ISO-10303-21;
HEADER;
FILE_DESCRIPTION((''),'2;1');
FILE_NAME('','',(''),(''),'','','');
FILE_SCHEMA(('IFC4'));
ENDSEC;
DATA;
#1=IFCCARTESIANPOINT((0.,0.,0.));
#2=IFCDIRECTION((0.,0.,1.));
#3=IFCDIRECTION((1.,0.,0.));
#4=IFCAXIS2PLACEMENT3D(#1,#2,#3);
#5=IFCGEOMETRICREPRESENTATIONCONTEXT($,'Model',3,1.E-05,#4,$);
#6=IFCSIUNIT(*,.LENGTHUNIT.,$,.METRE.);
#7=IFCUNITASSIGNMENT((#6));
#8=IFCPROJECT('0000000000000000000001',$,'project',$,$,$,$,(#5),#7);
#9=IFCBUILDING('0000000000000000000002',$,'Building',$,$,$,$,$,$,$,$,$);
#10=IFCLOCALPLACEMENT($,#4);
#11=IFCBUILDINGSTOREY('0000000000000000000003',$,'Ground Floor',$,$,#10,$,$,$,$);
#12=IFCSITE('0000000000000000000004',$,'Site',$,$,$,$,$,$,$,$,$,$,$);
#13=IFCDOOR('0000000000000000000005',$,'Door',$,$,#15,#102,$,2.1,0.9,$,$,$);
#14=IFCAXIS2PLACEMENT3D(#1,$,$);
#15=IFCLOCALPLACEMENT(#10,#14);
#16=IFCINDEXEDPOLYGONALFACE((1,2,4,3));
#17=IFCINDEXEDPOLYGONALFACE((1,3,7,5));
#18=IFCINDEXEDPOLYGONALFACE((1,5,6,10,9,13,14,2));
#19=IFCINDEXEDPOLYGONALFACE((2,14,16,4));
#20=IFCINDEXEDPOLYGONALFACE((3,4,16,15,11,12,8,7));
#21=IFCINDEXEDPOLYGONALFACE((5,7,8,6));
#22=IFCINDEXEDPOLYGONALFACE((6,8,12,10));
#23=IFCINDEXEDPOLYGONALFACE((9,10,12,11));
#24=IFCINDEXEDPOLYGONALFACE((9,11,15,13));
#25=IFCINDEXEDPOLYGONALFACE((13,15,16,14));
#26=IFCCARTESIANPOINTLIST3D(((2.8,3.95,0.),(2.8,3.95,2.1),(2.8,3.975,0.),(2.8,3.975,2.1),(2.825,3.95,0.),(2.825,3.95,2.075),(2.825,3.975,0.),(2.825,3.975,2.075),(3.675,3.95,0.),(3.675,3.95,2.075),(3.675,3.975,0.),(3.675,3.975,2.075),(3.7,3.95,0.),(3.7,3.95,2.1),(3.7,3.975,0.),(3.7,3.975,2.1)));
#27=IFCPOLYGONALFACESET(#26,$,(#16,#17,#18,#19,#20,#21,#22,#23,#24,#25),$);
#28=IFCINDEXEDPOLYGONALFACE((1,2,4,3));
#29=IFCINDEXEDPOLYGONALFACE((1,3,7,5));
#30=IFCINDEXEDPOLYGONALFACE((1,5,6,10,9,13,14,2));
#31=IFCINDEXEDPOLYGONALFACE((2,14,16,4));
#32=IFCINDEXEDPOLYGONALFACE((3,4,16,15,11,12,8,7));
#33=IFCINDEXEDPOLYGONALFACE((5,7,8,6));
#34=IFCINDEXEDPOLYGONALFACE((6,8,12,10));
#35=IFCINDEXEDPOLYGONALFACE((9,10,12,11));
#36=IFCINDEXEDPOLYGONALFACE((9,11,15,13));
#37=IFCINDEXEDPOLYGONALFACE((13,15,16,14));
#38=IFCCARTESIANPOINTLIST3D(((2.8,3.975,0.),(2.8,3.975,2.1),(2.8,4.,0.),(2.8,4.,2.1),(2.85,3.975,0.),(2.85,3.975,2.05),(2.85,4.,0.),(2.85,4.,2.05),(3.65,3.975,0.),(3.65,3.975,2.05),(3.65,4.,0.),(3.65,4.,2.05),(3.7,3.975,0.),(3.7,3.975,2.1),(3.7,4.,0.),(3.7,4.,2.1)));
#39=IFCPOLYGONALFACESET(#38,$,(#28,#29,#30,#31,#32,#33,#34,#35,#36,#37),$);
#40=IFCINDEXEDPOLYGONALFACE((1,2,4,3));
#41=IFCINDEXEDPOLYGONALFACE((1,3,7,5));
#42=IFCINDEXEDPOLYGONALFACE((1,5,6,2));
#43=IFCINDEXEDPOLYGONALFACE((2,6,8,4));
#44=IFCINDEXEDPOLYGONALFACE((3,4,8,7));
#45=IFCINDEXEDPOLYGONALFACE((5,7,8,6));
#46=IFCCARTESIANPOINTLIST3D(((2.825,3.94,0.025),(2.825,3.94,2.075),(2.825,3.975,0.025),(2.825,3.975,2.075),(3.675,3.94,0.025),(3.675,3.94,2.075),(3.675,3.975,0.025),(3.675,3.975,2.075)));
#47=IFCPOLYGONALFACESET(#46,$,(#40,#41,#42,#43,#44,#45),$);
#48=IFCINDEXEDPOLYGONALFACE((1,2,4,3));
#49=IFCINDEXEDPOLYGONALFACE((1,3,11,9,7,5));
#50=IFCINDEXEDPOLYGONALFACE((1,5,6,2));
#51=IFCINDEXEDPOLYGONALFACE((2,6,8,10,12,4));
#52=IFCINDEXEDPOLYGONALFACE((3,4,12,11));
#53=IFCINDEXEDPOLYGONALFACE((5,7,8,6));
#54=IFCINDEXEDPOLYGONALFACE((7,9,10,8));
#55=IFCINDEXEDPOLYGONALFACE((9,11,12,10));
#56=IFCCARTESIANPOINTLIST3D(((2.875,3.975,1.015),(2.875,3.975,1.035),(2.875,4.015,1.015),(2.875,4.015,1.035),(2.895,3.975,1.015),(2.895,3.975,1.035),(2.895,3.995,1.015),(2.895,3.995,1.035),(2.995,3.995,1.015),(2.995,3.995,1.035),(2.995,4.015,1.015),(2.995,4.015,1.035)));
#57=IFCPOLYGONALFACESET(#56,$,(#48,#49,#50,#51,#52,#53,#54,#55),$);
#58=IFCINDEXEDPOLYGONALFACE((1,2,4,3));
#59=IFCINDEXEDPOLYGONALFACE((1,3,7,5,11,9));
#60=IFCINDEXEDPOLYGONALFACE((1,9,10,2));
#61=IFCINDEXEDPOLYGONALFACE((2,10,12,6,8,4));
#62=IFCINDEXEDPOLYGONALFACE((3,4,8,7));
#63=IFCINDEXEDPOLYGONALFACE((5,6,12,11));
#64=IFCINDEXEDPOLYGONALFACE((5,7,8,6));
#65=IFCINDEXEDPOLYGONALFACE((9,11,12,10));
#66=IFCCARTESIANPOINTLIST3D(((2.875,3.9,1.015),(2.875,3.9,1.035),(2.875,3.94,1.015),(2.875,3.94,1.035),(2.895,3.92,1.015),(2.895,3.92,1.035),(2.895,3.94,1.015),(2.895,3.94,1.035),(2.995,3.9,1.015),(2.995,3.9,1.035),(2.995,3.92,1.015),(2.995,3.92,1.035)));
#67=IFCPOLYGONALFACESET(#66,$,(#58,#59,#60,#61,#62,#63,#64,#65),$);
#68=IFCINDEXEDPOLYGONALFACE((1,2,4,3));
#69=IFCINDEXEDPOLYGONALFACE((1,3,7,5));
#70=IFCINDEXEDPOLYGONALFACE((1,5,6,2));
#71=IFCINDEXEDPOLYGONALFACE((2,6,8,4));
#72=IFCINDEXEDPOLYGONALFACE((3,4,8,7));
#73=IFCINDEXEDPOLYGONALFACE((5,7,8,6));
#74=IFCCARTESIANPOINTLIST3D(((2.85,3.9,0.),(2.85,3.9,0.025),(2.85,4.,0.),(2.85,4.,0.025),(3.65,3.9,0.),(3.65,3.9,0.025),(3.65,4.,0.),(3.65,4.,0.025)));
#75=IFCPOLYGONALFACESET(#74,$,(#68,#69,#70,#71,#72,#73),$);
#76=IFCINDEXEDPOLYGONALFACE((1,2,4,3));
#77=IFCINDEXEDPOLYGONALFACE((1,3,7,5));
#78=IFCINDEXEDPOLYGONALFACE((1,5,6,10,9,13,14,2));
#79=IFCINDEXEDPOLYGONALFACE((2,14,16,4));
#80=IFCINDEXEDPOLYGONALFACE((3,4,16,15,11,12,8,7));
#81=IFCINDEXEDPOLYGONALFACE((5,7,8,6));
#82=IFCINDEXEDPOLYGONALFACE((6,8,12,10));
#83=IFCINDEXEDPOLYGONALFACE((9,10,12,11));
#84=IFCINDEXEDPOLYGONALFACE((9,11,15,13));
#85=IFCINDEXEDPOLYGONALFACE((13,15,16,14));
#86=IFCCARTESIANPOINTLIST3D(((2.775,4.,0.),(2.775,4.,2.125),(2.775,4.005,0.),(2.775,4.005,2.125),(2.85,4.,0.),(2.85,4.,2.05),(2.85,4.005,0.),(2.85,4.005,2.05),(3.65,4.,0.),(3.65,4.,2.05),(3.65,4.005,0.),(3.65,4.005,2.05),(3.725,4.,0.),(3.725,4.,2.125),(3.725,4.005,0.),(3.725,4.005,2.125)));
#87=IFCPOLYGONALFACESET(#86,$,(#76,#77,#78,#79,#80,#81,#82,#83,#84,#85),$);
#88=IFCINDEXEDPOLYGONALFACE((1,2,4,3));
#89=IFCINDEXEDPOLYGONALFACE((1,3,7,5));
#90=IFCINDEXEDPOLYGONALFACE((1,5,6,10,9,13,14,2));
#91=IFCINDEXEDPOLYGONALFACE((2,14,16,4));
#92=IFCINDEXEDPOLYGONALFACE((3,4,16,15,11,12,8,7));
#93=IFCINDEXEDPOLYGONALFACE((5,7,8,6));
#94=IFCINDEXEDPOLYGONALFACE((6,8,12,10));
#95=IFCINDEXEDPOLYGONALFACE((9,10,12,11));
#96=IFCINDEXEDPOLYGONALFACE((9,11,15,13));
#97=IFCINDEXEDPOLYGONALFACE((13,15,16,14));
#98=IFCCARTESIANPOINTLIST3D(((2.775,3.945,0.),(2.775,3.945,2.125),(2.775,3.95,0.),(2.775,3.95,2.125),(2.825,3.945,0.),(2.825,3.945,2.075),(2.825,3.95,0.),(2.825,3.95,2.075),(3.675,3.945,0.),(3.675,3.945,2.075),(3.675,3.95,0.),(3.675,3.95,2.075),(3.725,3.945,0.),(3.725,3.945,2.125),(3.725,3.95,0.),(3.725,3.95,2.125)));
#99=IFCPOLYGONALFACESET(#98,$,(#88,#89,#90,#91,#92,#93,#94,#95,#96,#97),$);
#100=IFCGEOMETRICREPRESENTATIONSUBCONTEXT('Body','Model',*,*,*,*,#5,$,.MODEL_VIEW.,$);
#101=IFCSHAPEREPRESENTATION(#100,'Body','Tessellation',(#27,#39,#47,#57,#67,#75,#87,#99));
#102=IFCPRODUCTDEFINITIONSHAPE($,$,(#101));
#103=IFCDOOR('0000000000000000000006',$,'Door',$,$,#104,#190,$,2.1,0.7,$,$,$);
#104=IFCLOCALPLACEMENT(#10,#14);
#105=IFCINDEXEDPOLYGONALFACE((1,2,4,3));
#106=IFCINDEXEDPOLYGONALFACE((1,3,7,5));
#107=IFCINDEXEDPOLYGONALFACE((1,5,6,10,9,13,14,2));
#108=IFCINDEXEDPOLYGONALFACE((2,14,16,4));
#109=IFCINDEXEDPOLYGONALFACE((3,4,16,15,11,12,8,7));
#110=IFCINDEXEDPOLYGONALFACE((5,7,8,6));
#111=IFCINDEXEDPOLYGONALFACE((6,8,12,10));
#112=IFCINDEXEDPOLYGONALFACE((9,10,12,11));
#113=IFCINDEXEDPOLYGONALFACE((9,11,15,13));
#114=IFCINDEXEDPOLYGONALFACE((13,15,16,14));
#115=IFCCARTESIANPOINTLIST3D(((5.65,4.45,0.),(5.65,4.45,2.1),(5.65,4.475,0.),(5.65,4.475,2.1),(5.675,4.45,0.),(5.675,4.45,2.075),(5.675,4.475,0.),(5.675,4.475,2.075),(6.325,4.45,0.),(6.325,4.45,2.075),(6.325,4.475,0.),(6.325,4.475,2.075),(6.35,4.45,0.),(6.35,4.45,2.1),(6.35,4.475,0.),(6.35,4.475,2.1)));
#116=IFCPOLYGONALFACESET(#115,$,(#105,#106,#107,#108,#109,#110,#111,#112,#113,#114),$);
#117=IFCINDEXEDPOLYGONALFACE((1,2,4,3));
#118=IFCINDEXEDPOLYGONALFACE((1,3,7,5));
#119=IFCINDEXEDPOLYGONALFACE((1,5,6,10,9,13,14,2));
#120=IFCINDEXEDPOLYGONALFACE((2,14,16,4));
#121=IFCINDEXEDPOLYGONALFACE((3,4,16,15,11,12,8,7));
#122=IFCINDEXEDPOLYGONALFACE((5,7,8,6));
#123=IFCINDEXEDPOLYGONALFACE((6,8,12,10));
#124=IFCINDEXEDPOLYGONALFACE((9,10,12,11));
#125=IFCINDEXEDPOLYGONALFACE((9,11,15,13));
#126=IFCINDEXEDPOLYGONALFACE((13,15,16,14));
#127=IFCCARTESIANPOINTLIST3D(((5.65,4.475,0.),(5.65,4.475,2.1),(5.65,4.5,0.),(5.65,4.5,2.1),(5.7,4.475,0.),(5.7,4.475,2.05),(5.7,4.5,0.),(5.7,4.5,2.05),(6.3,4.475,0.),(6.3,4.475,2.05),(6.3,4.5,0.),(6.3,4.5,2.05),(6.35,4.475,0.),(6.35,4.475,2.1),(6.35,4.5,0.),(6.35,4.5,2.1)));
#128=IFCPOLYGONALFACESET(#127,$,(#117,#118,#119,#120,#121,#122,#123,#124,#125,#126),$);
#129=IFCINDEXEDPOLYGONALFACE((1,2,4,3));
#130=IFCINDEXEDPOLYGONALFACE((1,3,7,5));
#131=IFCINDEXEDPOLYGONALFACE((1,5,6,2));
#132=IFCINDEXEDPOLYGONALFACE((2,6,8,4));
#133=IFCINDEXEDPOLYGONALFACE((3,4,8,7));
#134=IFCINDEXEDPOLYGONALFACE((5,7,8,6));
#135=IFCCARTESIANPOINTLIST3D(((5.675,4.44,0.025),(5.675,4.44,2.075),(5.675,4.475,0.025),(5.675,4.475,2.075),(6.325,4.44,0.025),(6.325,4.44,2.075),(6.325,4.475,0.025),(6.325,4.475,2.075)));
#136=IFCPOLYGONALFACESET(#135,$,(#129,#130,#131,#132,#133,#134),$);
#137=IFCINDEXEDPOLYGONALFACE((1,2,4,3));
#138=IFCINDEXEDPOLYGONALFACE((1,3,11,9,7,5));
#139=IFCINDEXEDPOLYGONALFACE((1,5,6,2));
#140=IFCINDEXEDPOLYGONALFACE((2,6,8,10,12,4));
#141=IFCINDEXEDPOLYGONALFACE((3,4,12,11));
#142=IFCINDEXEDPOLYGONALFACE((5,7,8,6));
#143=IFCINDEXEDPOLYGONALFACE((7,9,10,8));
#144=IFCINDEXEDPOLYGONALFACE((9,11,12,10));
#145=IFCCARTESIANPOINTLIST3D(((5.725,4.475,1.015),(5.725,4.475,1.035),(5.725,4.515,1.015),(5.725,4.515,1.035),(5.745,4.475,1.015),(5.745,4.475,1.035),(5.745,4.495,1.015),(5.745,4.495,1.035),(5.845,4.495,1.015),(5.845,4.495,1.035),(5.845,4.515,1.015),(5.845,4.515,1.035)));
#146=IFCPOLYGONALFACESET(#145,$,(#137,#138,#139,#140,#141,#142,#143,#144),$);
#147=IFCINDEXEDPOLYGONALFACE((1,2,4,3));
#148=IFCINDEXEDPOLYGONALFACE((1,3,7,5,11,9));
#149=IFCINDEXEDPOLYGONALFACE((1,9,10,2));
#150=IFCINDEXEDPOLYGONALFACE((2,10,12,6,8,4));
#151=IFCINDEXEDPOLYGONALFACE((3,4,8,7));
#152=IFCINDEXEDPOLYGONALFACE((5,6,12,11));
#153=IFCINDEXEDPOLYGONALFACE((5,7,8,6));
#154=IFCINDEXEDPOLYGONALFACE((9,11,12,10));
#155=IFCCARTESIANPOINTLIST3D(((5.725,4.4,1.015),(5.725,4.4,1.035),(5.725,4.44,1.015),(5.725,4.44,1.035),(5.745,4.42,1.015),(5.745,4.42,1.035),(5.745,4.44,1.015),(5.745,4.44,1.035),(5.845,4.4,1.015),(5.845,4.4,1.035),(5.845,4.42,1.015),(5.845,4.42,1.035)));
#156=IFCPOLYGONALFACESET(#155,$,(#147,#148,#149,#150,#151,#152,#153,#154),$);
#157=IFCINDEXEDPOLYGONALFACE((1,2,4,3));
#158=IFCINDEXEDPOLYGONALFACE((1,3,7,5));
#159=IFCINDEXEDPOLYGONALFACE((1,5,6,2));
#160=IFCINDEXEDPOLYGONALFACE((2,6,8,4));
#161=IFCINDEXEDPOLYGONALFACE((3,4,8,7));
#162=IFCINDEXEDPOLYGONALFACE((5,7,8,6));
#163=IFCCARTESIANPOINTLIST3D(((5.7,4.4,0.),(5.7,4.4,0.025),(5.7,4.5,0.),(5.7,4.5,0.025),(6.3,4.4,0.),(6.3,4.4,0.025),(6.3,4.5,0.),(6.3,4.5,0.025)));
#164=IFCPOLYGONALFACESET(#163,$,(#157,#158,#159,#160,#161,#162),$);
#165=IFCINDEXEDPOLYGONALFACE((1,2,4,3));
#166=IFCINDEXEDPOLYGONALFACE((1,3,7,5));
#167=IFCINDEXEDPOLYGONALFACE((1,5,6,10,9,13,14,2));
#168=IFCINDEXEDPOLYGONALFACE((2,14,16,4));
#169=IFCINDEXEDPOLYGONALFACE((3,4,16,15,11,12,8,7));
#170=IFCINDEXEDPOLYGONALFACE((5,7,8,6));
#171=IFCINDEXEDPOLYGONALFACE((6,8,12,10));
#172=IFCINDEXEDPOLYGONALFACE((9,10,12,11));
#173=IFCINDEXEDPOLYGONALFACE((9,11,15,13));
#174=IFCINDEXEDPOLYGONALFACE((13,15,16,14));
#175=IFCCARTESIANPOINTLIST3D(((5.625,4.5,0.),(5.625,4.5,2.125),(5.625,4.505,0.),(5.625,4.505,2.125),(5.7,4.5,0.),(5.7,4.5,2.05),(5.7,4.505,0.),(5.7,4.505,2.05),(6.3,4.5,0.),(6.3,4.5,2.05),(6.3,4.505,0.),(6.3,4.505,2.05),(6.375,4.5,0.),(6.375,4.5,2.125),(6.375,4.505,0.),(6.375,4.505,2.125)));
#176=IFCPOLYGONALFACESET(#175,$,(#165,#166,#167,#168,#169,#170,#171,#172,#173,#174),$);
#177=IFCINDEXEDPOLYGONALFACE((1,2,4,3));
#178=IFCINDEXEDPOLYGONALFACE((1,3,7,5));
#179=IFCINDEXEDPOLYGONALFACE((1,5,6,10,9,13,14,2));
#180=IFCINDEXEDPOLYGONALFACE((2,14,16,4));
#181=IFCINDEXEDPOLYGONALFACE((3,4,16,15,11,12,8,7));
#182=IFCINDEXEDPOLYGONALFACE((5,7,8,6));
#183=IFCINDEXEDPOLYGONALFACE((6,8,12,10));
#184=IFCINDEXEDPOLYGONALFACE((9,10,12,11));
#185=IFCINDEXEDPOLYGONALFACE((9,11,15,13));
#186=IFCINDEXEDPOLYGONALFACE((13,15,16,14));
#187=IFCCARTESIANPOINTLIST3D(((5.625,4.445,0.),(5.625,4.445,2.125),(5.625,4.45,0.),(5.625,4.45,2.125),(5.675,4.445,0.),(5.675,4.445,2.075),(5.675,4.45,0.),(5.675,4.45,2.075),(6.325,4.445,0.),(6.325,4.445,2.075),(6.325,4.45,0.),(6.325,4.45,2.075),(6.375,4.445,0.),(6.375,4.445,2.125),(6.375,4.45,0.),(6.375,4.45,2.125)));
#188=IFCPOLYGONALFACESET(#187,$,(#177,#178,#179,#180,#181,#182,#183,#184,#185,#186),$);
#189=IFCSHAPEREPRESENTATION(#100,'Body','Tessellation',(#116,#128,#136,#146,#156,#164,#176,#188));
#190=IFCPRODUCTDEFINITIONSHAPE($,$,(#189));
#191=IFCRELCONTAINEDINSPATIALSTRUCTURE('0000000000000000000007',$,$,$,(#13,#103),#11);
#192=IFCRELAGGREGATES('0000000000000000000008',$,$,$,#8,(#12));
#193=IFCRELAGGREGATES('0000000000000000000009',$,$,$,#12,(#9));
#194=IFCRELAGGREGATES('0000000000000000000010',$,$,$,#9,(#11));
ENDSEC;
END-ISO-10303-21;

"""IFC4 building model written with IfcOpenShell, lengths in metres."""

from ifc_helpers import new_model, si_unit, frame, origin_with_axes, place, context, subcontext, project, spatial, line, indexed_curve, outline, extrude, element, save


model = new_model("IFC4")

# Units and contexts
model_context = context("Model", 3, precision=1e-05, world=origin_with_axes())
body_context = subcontext(model_context, "Body", "Model", "MODEL_VIEW")
ifc_project = project(units=[si_unit("LENGTHUNIT", "METRE")], contexts=[model_context])

# Site, building, storey
site = spatial("IfcSite", under=ifc_project, Name="Site")
building = spatial("IfcBuilding", under=site, Name="Building")
storey_placement = place(None, origin_with_axes())
storey = spatial("IfcBuildingStorey", under=building, at=storey_placement, Name="Ground Floor")

# Doors
door_1_placement = place(storey_placement, frame((3.7, 4.0, 0.0), z_axis=(0.0, 0.0, 1.0), x_axis=(-1.0, 0.0, 0.0)))
element("IfcDoor", 1, at=door_1_placement, inside=storey, Name="Door", OverallHeight=2.1, OverallWidth=0.9, context=body_context, shape_type="SweptSolid", body=[
    extrude(outline(indexed_curve([(0.0, 0.0), (0.0, 2.1), (0.9, 2.1), (0.9, 0.0), (0.875, 0.0), (0.875, 2.075), (0.025, 2.075), (0.025, 0.0)], segments=[line(1, 2, 3, 4, 5, 6, 7, 8, 1)])), frame((0.0, 0.025, 0.0), z_axis=(0.0, -1.0, 0.0), x_axis=(1.0, 0.0, 0.0)), (0.0, 0.0, -1.0), 0.025),
    extrude(outline(indexed_curve([(0.0, 0.0), (0.0, 2.1), (0.9, 2.1), (0.9, 0.0), (0.85, 0.0), (0.85, 2.05), (0.05, 2.05), (0.05, 0.0)], segments=[line(1, 2, 3, 4, 5, 6, 7, 8, 1)])), frame((0.0, 0.0, 0.0), z_axis=(0.0, -1.0, 0.0), x_axis=(1.0, 0.0, 0.0)), (0.0, 0.0, -1.0), 0.025),
    extrude(outline(indexed_curve([(0.0, 0.0), (0.85, 0.0), (0.85, 0.035), (0.0, 0.035)], segments=[line(1, 2, 3, 4, 1)])), frame((0.025, 0.025, 0.025), z_axis=(0.0, 0.0, 1.0), x_axis=(1.0, 0.0, 0.0)), (0.0, 0.0, 1.0), 2.05),
    extrude(outline(indexed_curve([(0.0, 0.0), (0.0, -0.04), (-0.12, -0.04), (-0.12, -0.02), (-0.02, -0.02), (-0.02, 0.0)], segments=[line(1, 2, 3, 4, 5, 6, 1)])), frame((0.825, 0.025, 1.015), z_axis=(0.0, 0.0, 1.0), x_axis=(1.0, 0.0, 0.0)), (0.0, 0.0, 1.0), 0.02),
    extrude(outline(indexed_curve([(0.0, 0.0), (0.0, 0.04), (-0.12, 0.04), (-0.12, 0.02), (-0.02, 0.02), (-0.02, 0.0)], segments=[line(1, 2, 3, 4, 5, 6, 1)])), frame((0.825, 0.06, 1.015), z_axis=(0.0, 0.0, 1.0), x_axis=(1.0, 0.0, 0.0)), (0.0, 0.0, 1.0), 0.02),
    extrude(outline(indexed_curve([(0.0, 0.0), (0.8, 0.0), (0.8, 0.1), (0.0, 0.1)], segments=[line(1, 2, 3, 4, 1)])), frame((0.05, 0.0, 0.0), z_axis=(0.0, 0.0, 1.0), x_axis=(1.0, 0.0, 0.0)), (0.0, 0.0, 1.0), 0.025),
    extrude(outline(indexed_curve([(0.0, 0.0), (0.0, 2.125), (0.95, 2.125), (0.95, 0.0), (0.875, 0.0), (0.875, 2.05), (0.075, 2.05), (0.075, 0.0)], segments=[line(1, 2, 3, 4, 5, 6, 7, 8, 1)])), frame((-0.025, -0.005, 0.0), z_axis=(0.0, -1.0, 0.0), x_axis=(1.0, 0.0, 0.0)), (0.0, 0.0, -1.0), 0.005),
    extrude(outline(indexed_curve([(0.0, 0.0), (0.0, 2.125), (0.95, 2.125), (0.95, 0.0), (0.9, 0.0), (0.9, 2.075), (0.05, 2.075), (0.05, 0.0)], segments=[line(1, 2, 3, 4, 5, 6, 7, 8, 1)])), frame((-0.025, 0.05, 0.0), z_axis=(0.0, -1.0, 0.0), x_axis=(1.0, 0.0, 0.0)), (0.0, 0.0, -1.0), 0.005),
])
door_2_placement = place(storey_placement, frame((6.35, 4.5, 0.0), z_axis=(0.0, 0.0, 1.0), x_axis=(-1.0, 0.0, 0.0)))
element("IfcDoor", 2, at=door_2_placement, inside=storey, Name="Door", OverallHeight=2.1, OverallWidth=0.7, context=body_context, shape_type="SweptSolid", body=[
    extrude(outline(indexed_curve([(0.0, 0.0), (0.0, 2.1), (0.7, 2.1), (0.7, 0.0), (0.675, 0.0), (0.675, 2.075), (0.025, 2.075), (0.025, 0.0)], segments=[line(1, 2, 3, 4, 5, 6, 7, 8, 1)])), frame((0.0, 0.025, 0.0), z_axis=(0.0, -1.0, 0.0), x_axis=(1.0, 0.0, 0.0)), (0.0, 0.0, -1.0), 0.025),
    extrude(outline(indexed_curve([(0.0, 0.0), (0.0, 2.1), (0.7, 2.1), (0.7, 0.0), (0.65, 0.0), (0.65, 2.05), (0.05, 2.05), (0.05, 0.0)], segments=[line(1, 2, 3, 4, 5, 6, 7, 8, 1)])), frame((0.0, 0.0, 0.0), z_axis=(0.0, -1.0, 0.0), x_axis=(1.0, 0.0, 0.0)), (0.0, 0.0, -1.0), 0.025),
    extrude(outline(indexed_curve([(0.0, 0.0), (0.65, 0.0), (0.65, 0.035), (0.0, 0.035)], segments=[line(1, 2, 3, 4, 1)])), frame((0.025, 0.025, 0.025), z_axis=(0.0, 0.0, 1.0), x_axis=(1.0, 0.0, 0.0)), (0.0, 0.0, 1.0), 2.05),
    extrude(outline(indexed_curve([(0.0, 0.0), (0.0, -0.04), (-0.12, -0.04), (-0.12, -0.02), (-0.02, -0.02), (-0.02, 0.0)], segments=[line(1, 2, 3, 4, 5, 6, 1)])), frame((0.625, 0.025, 1.015), z_axis=(0.0, 0.0, 1.0), x_axis=(1.0, 0.0, 0.0)), (0.0, 0.0, 1.0), 0.02),
    extrude(outline(indexed_curve([(0.0, 0.0), (0.0, 0.04), (-0.12, 0.04), (-0.12, 0.02), (-0.02, 0.02), (-0.02, 0.0)], segments=[line(1, 2, 3, 4, 5, 6, 1)])), frame((0.625, 0.06, 1.015), z_axis=(0.0, 0.0, 1.0), x_axis=(1.0, 0.0, 0.0)), (0.0, 0.0, 1.0), 0.02),
    extrude(outline(indexed_curve([(0.0, 0.0), (0.6, 0.0), (0.6, 0.1), (0.0, 0.1)], segments=[line(1, 2, 3, 4, 1)])), frame((0.05, 0.0, 0.0), z_axis=(0.0, 0.0, 1.0), x_axis=(1.0, 0.0, 0.0)), (0.0, 0.0, 1.0), 0.025),
    extrude(outline(indexed_curve([(0.0, 0.0), (0.0, 2.125), (0.75, 2.125), (0.75, 0.0), (0.675, 0.0), (0.675, 2.05), (0.075, 2.05), (0.075, 0.0)], segments=[line(1, 2, 3, 4, 5, 6, 7, 8, 1)])), frame((-0.025, -0.005, 0.0), z_axis=(0.0, -1.0, 0.0), x_axis=(1.0, 0.0, 0.0)), (0.0, 0.0, -1.0), 0.005),
    extrude(outline(indexed_curve([(0.0, 0.0), (0.0, 2.125), (0.75, 2.125), (0.75, 0.0), (0.7, 0.0), (0.7, 2.075), (0.05, 2.075), (0.05, 0.0)], segments=[line(1, 2, 3, 4, 5, 6, 7, 8, 1)])), frame((-0.025, 0.05, 0.0), z_axis=(0.0, -1.0, 0.0), x_axis=(1.0, 0.0, 0.0)), (0.0, 0.0, -1.0), 0.005),
])

save(model, "model.ifc")
